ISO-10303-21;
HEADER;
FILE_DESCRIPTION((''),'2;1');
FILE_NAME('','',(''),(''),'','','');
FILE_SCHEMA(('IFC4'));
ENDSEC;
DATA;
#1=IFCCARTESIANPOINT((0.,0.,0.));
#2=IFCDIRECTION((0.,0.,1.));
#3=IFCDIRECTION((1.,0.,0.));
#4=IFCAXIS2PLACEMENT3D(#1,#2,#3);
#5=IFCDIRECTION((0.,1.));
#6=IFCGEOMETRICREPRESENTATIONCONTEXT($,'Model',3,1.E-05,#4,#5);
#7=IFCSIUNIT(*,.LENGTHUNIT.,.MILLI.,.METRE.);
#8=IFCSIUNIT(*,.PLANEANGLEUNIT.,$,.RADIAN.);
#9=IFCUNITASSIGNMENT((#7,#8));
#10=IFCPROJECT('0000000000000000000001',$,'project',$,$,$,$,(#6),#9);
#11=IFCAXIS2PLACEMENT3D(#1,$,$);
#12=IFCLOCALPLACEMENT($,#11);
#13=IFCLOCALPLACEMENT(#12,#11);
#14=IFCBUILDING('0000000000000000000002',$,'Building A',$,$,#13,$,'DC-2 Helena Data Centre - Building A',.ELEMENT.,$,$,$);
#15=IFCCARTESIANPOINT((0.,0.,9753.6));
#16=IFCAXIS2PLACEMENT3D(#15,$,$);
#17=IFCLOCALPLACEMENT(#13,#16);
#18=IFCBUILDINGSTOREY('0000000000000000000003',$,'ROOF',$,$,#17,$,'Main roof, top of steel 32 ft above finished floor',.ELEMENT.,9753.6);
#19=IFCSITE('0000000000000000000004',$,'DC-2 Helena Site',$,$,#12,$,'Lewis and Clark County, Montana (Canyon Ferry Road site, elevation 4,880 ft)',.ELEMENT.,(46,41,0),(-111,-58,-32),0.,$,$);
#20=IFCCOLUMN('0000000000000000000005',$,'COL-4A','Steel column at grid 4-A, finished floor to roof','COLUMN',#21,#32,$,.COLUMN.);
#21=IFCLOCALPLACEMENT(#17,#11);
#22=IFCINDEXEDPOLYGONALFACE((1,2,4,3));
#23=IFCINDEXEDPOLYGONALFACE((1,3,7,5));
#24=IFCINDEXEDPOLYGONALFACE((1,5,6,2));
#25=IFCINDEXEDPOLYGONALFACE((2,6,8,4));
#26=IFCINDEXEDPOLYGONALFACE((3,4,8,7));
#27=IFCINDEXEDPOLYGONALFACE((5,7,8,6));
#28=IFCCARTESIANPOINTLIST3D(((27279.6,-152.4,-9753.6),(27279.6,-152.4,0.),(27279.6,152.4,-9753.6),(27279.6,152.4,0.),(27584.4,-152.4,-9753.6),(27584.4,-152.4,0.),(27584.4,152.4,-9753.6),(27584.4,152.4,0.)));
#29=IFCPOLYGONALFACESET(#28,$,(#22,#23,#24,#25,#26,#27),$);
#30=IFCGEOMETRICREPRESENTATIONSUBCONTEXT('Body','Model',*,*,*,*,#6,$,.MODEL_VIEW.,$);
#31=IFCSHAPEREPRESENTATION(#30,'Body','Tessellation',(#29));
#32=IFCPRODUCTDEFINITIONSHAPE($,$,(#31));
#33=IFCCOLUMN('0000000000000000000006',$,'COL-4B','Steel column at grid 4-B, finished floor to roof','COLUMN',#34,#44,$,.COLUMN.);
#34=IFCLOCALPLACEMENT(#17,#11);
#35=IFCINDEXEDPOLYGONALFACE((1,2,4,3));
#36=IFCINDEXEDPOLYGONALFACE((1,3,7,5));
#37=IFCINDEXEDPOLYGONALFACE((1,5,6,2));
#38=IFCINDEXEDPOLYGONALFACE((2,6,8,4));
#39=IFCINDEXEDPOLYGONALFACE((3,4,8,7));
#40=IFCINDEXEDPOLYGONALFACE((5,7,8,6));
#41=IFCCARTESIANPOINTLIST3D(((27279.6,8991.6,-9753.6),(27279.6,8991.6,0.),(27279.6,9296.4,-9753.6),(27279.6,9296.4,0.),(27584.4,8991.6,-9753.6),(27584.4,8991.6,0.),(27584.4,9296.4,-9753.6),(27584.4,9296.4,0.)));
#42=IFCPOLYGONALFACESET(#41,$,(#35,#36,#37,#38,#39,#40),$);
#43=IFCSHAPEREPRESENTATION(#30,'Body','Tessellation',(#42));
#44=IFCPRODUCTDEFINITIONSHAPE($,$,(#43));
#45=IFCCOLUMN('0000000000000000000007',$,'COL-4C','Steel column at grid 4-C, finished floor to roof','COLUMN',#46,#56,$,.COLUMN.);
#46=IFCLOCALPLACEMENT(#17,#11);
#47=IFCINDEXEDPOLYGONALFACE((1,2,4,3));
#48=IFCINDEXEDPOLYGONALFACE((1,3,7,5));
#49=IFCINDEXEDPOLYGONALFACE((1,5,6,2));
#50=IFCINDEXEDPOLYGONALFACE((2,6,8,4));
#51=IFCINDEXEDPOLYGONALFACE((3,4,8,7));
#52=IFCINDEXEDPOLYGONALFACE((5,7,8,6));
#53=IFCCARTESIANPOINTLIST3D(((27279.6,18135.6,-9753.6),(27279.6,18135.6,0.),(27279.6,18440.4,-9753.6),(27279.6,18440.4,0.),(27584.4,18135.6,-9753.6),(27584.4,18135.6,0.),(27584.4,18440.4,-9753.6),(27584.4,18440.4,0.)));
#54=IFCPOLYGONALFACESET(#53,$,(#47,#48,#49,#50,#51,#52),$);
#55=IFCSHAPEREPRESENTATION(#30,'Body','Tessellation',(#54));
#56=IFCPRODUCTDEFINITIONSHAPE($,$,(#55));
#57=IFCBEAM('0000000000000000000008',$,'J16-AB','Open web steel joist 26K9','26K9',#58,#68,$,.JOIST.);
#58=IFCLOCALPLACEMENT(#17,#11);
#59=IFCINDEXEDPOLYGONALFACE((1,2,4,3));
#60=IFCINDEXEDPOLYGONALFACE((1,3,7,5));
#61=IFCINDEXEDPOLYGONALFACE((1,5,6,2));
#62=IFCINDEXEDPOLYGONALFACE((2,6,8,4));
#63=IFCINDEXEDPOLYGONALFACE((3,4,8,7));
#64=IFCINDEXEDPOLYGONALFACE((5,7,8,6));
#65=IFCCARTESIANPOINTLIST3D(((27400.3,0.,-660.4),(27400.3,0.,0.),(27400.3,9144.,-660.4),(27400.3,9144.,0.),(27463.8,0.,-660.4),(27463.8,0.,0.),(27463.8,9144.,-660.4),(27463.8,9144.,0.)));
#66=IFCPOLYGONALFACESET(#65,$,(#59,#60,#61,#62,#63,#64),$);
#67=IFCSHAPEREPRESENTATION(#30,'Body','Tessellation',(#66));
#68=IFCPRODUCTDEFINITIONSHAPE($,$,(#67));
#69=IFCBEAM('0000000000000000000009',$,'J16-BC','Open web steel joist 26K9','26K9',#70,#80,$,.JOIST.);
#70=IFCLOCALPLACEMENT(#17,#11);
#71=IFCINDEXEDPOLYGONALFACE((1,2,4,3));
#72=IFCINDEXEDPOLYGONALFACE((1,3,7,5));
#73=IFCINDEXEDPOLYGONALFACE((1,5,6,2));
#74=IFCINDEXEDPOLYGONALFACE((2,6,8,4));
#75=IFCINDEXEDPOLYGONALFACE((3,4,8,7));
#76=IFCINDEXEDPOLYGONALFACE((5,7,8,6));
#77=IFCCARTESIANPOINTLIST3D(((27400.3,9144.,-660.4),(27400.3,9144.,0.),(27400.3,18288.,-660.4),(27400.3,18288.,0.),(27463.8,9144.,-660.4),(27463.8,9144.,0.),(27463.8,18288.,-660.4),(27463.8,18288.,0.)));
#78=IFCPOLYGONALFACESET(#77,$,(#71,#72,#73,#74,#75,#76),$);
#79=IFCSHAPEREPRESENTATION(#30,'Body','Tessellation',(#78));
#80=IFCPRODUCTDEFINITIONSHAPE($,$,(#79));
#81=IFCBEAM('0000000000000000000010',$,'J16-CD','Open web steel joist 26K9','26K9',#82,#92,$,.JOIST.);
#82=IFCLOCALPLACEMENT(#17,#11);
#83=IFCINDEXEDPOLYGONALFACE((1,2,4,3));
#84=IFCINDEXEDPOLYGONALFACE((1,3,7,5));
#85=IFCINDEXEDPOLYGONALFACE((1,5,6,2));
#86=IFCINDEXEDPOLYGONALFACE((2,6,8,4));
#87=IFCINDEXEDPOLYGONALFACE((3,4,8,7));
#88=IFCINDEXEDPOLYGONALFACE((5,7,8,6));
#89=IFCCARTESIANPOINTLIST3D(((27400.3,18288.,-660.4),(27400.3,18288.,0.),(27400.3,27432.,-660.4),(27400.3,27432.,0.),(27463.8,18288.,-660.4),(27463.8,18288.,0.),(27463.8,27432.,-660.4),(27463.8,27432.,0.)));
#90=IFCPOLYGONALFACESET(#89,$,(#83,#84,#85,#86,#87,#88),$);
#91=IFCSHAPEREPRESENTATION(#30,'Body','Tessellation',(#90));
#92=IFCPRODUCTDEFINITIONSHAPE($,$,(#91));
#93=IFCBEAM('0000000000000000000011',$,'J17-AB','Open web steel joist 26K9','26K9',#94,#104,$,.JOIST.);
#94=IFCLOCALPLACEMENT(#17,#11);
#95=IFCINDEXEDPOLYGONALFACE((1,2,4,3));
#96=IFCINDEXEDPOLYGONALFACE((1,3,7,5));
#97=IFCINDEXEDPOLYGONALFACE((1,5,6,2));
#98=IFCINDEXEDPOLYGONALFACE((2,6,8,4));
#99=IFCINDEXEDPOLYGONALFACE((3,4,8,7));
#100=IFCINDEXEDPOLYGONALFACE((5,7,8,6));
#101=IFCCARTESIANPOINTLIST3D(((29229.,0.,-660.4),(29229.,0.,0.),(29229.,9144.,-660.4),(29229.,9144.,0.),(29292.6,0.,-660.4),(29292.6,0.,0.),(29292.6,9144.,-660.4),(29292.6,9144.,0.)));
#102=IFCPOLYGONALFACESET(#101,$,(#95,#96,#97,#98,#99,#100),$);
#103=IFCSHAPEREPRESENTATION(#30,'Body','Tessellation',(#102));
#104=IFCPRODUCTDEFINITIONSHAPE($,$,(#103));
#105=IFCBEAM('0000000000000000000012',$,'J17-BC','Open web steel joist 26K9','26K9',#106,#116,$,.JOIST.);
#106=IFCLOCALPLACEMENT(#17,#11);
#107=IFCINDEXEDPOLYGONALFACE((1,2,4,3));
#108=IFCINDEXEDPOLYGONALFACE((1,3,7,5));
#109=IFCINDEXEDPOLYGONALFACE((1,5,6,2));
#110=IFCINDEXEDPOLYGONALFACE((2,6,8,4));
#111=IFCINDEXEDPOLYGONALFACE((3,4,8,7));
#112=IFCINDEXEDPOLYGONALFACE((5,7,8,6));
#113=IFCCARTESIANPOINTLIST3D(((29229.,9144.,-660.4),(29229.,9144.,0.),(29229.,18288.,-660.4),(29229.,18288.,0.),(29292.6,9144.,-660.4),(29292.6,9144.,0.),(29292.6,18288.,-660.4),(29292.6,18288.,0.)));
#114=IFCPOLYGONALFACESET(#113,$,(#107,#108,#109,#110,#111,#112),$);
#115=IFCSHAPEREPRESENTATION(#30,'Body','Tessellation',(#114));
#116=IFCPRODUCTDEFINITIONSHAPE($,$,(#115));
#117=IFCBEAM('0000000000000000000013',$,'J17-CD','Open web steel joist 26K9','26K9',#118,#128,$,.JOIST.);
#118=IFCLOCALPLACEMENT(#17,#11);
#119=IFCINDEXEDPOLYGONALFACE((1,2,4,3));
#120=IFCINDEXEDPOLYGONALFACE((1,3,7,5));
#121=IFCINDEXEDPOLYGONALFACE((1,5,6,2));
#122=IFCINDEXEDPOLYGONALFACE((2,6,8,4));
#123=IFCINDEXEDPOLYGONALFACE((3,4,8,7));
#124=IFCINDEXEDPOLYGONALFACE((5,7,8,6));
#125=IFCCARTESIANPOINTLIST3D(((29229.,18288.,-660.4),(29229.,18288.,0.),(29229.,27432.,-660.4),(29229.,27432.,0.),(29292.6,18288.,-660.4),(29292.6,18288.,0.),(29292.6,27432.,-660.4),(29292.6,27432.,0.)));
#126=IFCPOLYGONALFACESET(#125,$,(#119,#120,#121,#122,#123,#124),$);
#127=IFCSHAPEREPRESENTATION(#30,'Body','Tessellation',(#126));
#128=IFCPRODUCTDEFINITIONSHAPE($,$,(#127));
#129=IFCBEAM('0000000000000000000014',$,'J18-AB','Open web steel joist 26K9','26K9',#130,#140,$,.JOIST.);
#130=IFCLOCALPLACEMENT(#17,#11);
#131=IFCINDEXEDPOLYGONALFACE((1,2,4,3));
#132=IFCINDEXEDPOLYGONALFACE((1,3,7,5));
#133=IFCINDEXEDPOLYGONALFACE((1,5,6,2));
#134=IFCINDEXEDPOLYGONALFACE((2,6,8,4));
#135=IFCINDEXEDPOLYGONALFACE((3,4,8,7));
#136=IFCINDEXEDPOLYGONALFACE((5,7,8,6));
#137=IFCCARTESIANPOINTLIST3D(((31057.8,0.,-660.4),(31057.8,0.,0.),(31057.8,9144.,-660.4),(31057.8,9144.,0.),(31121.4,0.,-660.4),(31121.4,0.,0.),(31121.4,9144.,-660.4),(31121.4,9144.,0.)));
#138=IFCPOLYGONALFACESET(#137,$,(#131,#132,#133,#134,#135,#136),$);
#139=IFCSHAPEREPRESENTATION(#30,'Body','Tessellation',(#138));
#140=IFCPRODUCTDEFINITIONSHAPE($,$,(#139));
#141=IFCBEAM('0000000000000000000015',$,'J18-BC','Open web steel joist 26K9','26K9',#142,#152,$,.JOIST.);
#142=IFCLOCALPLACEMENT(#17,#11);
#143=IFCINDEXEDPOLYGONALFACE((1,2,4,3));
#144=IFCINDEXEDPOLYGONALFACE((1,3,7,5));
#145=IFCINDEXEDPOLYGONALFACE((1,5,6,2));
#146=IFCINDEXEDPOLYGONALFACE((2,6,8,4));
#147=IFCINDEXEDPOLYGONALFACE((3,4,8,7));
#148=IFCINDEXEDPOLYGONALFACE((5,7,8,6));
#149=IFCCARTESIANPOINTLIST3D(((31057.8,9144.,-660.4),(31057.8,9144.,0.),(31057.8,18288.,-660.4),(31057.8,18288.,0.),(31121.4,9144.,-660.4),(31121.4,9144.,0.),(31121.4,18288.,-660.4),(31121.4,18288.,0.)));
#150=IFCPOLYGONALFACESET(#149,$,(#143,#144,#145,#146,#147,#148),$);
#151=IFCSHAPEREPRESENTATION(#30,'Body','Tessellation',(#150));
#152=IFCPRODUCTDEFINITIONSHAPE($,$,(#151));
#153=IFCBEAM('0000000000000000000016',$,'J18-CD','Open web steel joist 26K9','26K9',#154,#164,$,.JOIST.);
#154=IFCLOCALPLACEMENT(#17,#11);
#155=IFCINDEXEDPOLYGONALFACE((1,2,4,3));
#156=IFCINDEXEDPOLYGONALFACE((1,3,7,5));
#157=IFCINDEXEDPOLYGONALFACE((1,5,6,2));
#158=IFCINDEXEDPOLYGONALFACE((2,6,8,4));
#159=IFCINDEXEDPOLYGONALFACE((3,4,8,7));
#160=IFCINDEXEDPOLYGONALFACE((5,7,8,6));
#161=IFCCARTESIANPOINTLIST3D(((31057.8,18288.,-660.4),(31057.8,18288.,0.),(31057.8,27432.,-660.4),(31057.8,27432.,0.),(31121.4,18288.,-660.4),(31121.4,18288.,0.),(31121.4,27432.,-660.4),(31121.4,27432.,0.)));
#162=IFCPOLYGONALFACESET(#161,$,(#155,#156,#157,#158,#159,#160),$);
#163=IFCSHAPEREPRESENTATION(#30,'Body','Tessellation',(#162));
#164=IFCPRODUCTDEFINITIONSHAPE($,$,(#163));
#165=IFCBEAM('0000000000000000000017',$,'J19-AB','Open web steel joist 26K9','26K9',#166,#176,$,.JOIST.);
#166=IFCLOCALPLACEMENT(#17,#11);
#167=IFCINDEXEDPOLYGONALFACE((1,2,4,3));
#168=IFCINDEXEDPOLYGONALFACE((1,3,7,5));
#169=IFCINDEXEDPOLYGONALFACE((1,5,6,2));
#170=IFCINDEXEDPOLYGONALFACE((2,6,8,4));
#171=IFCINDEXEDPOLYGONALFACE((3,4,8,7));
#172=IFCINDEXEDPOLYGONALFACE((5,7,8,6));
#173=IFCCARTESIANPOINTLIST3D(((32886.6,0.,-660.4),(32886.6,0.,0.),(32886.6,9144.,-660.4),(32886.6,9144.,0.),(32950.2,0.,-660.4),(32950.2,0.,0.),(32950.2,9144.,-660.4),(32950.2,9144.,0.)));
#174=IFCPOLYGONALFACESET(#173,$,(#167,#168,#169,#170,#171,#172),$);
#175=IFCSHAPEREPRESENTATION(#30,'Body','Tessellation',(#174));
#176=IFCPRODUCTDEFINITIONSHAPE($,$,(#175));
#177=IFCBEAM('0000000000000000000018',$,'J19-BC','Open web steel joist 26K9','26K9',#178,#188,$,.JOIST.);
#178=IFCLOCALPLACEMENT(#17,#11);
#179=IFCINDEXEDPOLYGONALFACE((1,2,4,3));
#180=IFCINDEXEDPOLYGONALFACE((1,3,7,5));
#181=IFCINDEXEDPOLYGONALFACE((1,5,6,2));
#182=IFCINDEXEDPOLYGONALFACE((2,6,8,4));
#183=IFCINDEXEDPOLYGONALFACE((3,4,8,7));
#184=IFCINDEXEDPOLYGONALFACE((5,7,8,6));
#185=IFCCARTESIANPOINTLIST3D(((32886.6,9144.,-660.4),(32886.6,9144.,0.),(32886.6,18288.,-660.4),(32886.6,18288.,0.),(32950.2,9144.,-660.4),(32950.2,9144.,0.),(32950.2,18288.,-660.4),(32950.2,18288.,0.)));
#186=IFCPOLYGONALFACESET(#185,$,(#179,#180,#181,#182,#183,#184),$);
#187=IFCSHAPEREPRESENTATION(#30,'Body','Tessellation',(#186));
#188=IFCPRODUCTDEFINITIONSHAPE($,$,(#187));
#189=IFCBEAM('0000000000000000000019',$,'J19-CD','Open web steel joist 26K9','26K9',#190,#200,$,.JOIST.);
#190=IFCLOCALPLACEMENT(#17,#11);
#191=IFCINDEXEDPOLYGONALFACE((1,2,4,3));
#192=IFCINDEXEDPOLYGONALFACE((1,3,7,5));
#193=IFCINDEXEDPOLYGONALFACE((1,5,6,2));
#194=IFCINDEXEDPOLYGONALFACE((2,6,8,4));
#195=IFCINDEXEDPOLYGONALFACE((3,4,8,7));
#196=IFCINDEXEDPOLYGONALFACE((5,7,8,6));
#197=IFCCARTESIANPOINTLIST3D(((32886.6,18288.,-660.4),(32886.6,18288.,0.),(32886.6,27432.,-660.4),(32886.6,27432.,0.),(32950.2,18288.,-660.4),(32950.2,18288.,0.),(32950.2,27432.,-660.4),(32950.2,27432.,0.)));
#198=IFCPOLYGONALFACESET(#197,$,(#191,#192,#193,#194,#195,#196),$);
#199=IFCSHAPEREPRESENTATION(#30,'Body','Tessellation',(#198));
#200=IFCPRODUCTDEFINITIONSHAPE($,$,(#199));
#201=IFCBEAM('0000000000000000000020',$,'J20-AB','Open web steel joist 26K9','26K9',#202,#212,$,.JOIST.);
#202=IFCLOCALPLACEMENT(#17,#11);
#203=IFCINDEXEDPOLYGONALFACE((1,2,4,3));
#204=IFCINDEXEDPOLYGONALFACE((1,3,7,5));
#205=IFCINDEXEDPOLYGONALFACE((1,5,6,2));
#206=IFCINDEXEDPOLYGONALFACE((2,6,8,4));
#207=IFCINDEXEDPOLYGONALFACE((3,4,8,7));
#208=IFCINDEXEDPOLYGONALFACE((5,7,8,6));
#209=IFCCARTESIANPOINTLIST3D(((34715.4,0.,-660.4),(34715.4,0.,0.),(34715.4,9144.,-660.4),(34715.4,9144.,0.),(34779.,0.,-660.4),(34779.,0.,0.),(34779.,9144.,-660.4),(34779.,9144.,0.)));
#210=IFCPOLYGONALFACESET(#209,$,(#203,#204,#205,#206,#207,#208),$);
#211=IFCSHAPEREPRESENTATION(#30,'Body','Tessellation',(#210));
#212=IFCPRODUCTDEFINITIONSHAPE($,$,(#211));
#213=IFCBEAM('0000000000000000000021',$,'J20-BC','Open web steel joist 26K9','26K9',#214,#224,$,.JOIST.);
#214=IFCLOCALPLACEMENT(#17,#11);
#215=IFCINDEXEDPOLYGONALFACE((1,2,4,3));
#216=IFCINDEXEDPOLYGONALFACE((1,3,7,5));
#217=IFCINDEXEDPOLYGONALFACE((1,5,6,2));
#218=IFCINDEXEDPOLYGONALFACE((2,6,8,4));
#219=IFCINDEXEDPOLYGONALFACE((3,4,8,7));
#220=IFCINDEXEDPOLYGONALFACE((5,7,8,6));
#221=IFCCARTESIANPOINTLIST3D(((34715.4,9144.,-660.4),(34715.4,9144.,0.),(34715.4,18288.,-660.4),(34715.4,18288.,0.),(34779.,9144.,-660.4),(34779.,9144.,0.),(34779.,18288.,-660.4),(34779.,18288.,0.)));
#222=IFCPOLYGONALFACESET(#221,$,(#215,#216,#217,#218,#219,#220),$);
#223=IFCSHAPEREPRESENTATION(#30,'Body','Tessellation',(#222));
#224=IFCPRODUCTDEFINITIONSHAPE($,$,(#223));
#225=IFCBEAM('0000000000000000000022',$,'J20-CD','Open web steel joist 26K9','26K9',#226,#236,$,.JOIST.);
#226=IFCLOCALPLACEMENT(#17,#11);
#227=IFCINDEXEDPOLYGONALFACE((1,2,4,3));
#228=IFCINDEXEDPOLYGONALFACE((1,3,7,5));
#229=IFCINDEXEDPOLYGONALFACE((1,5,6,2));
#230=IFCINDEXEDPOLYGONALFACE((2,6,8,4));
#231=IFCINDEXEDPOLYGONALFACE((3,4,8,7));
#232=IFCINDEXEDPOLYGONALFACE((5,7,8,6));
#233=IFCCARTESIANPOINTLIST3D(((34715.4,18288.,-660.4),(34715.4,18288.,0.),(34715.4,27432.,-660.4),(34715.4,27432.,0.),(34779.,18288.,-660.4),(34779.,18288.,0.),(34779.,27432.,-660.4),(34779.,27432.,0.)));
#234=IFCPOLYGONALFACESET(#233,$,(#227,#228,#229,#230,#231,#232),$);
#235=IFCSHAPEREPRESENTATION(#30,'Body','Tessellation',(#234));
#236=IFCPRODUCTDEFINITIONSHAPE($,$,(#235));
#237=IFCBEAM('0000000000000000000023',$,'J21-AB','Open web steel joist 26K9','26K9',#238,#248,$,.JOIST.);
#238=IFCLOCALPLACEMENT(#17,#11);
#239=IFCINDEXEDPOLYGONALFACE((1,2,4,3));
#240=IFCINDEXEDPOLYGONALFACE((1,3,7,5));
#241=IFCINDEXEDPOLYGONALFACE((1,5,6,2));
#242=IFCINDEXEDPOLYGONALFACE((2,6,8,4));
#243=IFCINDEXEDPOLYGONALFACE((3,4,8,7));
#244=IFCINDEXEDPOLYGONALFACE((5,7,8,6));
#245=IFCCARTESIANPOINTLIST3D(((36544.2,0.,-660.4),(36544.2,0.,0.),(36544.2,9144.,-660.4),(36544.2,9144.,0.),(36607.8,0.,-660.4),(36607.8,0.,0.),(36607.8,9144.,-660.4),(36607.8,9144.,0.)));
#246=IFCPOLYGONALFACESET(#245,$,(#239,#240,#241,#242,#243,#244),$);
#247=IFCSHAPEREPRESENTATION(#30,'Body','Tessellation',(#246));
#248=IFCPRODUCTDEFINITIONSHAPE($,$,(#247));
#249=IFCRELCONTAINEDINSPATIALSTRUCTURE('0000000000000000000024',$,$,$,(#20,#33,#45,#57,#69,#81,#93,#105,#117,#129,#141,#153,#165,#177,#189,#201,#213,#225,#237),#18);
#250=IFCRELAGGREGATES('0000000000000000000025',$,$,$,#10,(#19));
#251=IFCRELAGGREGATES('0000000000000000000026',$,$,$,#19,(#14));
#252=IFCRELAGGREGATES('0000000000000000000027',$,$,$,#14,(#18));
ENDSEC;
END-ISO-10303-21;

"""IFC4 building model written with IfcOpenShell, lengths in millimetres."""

from ifc_helpers import new_model, si_unit, direction, frame, origin, origin_with_axes, origin_2d, place, context, subcontext, project, spatial, rectangle, extrude, element, save


model = new_model("IFC4")

# Units and contexts
model_context = context("Model", 3, precision=1e-05, world=origin_with_axes(), true_north=direction((0.0, 1.0)))
body_context = subcontext(model_context, "Body", "Model", "MODEL_VIEW")
ifc_project = project(units=[si_unit("LENGTHUNIT", "METRE", prefix="MILLI"), si_unit("PLANEANGLEUNIT", "RADIAN")], contexts=[model_context])

# Site, building, storey
site_placement = place(None, origin())
site = spatial("IfcSite", under=ifc_project, at=site_placement, Name="DC-2 Helena Site", LongName="Lewis and Clark County, Montana (Canyon Ferry Road site, elevation 4,880 ft)", CompositionType="ELEMENT", RefLatitude=(46, 41, 0), RefLongitude=(-111, -58, -32), RefElevation=0.0)
building_placement = place(site_placement, origin())
building = spatial("IfcBuilding", under=site, at=building_placement, Name="Building A", LongName="DC-2 Helena Data Centre - Building A", CompositionType="ELEMENT")
storey_placement = place(building_placement, frame((0.0, 0.0, 9753.6)))
storey = spatial("IfcBuildingStorey", under=building, at=storey_placement, Name="ROOF", LongName="Main roof, top of steel 32 ft above finished floor", CompositionType="ELEMENT", Elevation=9753.6)

# Columns
for number, where, name, description in (
    (1, (27432.0, 0.0, -9753.6), "COL-4A", "Steel column at grid 4-A, finished floor to roof"),
    (2, (27432.0, 9144.0, -9753.6), "COL-4B", "Steel column at grid 4-B, finished floor to roof"),
    (3, (27432.0, 18288.0, -9753.6), "COL-4C", "Steel column at grid 4-C, finished floor to roof"),
):
    element("IfcColumn", number, at=place(storey_placement, frame(where)), inside=storey, Name=name, Description=description, ObjectType="COLUMN", PredefinedType="COLUMN", context=body_context, shape_type="SweptSolid", body=[
        extrude(rectangle(XDim=304.8, YDim=304.8, at=origin_2d()), origin(), (0.0, 0.0, 1.0), 9753.6),
    ])

# Beams
placement_1 = place(storey_placement, frame((27432.0, 0.0, 0.0)))
element("IfcBeam", 4, at=placement_1, inside=storey, Name="J16-AB", Description="Open web steel joist 26K9", ObjectType="26K9", PredefinedType="JOIST", context=body_context, shape_type="SweptSolid", body=[
    extrude(rectangle(XDim=63.5, YDim=660.4, at=origin_2d()), frame((0.0, 0.0, -330.2), z_axis=(0.0, 1.0, 0.0), x_axis=(1.0, 0.0, 0.0)), (0.0, 0.0, 1.0), 9144.0),
])
placement_2 = place(storey_placement, frame((27432.0, 9144.0, 0.0)))
element("IfcBeam", 5, at=placement_2, inside=storey, Name="J16-BC", Description="Open web steel joist 26K9", ObjectType="26K9", PredefinedType="JOIST", context=body_context, shape_type="SweptSolid", body=[
    extrude(rectangle(XDim=63.5, YDim=660.4, at=origin_2d()), frame((0.0, 0.0, -330.2), z_axis=(0.0, 1.0, 0.0), x_axis=(1.0, 0.0, 0.0)), (0.0, 0.0, 1.0), 9144.0),
])
placement_3 = place(storey_placement, frame((27432.0, 18288.0, 0.0)))
element("IfcBeam", 6, at=placement_3, inside=storey, Name="J16-CD", Description="Open web steel joist 26K9", ObjectType="26K9", PredefinedType="JOIST", context=body_context, shape_type="SweptSolid", body=[
    extrude(rectangle(XDim=63.5, YDim=660.4, at=origin_2d()), frame((0.0, 0.0, -330.2), z_axis=(0.0, 1.0, 0.0), x_axis=(1.0, 0.0, 0.0)), (0.0, 0.0, 1.0), 9144.0),
])
for number, where, name in (
    (7, (29260.8, 0.0, 0.0), "J17-AB"),
    (8, (29260.8, 9144.0, 0.0), "J17-BC"),
    (9, (29260.8, 18288.0, 0.0), "J17-CD"),
    (10, (31089.6, 0.0, 0.0), "J18-AB"),
    (11, (31089.6, 9144.0, 0.0), "J18-BC"),
    (12, (31089.6, 18288.0, 0.0), "J18-CD"),
    (13, (32918.4, 0.0, 0.0), "J19-AB"),
    (14, (32918.4, 9144.0, 0.0), "J19-BC"),
    (15, (32918.4, 18288.0, 0.0), "J19-CD"),
    (16, (34747.2, 0.0, 0.0), "J20-AB"),
    (17, (34747.2, 9144.0, 0.0), "J20-BC"),
    (18, (34747.2, 18288.0, 0.0), "J20-CD"),
):
    element("IfcBeam", number, at=place(storey_placement, frame(where)), inside=storey, Name=name, Description="Open web steel joist 26K9", ObjectType="26K9", PredefinedType="JOIST", context=body_context, shape_type="SweptSolid", body=[
        extrude(rectangle(XDim=63.5, YDim=660.4, at=origin_2d()), frame((0.0, 0.0, -330.2), z_axis=(0.0, 1.0, 0.0), x_axis=(1.0, 0.0, 0.0)), (0.0, 0.0, 1.0), 9144.0),
    ])
placement_4 = place(storey_placement, frame((36576.0, 0.0, 0.0)))
element("IfcBeam", 19, at=placement_4, inside=storey, Name="J21-AB", Description="Open web steel joist 26K9", ObjectType="26K9", PredefinedType="JOIST", context=body_context, shape_type="SweptSolid", body=[
    extrude(rectangle(XDim=63.5, YDim=660.4, at=origin_2d()), frame((0.0, 0.0, -330.2), z_axis=(0.0, 1.0, 0.0), x_axis=(1.0, 0.0, 0.0)), (0.0, 0.0, 1.0), 9144.0),
])

save(model, "model.ifc")
